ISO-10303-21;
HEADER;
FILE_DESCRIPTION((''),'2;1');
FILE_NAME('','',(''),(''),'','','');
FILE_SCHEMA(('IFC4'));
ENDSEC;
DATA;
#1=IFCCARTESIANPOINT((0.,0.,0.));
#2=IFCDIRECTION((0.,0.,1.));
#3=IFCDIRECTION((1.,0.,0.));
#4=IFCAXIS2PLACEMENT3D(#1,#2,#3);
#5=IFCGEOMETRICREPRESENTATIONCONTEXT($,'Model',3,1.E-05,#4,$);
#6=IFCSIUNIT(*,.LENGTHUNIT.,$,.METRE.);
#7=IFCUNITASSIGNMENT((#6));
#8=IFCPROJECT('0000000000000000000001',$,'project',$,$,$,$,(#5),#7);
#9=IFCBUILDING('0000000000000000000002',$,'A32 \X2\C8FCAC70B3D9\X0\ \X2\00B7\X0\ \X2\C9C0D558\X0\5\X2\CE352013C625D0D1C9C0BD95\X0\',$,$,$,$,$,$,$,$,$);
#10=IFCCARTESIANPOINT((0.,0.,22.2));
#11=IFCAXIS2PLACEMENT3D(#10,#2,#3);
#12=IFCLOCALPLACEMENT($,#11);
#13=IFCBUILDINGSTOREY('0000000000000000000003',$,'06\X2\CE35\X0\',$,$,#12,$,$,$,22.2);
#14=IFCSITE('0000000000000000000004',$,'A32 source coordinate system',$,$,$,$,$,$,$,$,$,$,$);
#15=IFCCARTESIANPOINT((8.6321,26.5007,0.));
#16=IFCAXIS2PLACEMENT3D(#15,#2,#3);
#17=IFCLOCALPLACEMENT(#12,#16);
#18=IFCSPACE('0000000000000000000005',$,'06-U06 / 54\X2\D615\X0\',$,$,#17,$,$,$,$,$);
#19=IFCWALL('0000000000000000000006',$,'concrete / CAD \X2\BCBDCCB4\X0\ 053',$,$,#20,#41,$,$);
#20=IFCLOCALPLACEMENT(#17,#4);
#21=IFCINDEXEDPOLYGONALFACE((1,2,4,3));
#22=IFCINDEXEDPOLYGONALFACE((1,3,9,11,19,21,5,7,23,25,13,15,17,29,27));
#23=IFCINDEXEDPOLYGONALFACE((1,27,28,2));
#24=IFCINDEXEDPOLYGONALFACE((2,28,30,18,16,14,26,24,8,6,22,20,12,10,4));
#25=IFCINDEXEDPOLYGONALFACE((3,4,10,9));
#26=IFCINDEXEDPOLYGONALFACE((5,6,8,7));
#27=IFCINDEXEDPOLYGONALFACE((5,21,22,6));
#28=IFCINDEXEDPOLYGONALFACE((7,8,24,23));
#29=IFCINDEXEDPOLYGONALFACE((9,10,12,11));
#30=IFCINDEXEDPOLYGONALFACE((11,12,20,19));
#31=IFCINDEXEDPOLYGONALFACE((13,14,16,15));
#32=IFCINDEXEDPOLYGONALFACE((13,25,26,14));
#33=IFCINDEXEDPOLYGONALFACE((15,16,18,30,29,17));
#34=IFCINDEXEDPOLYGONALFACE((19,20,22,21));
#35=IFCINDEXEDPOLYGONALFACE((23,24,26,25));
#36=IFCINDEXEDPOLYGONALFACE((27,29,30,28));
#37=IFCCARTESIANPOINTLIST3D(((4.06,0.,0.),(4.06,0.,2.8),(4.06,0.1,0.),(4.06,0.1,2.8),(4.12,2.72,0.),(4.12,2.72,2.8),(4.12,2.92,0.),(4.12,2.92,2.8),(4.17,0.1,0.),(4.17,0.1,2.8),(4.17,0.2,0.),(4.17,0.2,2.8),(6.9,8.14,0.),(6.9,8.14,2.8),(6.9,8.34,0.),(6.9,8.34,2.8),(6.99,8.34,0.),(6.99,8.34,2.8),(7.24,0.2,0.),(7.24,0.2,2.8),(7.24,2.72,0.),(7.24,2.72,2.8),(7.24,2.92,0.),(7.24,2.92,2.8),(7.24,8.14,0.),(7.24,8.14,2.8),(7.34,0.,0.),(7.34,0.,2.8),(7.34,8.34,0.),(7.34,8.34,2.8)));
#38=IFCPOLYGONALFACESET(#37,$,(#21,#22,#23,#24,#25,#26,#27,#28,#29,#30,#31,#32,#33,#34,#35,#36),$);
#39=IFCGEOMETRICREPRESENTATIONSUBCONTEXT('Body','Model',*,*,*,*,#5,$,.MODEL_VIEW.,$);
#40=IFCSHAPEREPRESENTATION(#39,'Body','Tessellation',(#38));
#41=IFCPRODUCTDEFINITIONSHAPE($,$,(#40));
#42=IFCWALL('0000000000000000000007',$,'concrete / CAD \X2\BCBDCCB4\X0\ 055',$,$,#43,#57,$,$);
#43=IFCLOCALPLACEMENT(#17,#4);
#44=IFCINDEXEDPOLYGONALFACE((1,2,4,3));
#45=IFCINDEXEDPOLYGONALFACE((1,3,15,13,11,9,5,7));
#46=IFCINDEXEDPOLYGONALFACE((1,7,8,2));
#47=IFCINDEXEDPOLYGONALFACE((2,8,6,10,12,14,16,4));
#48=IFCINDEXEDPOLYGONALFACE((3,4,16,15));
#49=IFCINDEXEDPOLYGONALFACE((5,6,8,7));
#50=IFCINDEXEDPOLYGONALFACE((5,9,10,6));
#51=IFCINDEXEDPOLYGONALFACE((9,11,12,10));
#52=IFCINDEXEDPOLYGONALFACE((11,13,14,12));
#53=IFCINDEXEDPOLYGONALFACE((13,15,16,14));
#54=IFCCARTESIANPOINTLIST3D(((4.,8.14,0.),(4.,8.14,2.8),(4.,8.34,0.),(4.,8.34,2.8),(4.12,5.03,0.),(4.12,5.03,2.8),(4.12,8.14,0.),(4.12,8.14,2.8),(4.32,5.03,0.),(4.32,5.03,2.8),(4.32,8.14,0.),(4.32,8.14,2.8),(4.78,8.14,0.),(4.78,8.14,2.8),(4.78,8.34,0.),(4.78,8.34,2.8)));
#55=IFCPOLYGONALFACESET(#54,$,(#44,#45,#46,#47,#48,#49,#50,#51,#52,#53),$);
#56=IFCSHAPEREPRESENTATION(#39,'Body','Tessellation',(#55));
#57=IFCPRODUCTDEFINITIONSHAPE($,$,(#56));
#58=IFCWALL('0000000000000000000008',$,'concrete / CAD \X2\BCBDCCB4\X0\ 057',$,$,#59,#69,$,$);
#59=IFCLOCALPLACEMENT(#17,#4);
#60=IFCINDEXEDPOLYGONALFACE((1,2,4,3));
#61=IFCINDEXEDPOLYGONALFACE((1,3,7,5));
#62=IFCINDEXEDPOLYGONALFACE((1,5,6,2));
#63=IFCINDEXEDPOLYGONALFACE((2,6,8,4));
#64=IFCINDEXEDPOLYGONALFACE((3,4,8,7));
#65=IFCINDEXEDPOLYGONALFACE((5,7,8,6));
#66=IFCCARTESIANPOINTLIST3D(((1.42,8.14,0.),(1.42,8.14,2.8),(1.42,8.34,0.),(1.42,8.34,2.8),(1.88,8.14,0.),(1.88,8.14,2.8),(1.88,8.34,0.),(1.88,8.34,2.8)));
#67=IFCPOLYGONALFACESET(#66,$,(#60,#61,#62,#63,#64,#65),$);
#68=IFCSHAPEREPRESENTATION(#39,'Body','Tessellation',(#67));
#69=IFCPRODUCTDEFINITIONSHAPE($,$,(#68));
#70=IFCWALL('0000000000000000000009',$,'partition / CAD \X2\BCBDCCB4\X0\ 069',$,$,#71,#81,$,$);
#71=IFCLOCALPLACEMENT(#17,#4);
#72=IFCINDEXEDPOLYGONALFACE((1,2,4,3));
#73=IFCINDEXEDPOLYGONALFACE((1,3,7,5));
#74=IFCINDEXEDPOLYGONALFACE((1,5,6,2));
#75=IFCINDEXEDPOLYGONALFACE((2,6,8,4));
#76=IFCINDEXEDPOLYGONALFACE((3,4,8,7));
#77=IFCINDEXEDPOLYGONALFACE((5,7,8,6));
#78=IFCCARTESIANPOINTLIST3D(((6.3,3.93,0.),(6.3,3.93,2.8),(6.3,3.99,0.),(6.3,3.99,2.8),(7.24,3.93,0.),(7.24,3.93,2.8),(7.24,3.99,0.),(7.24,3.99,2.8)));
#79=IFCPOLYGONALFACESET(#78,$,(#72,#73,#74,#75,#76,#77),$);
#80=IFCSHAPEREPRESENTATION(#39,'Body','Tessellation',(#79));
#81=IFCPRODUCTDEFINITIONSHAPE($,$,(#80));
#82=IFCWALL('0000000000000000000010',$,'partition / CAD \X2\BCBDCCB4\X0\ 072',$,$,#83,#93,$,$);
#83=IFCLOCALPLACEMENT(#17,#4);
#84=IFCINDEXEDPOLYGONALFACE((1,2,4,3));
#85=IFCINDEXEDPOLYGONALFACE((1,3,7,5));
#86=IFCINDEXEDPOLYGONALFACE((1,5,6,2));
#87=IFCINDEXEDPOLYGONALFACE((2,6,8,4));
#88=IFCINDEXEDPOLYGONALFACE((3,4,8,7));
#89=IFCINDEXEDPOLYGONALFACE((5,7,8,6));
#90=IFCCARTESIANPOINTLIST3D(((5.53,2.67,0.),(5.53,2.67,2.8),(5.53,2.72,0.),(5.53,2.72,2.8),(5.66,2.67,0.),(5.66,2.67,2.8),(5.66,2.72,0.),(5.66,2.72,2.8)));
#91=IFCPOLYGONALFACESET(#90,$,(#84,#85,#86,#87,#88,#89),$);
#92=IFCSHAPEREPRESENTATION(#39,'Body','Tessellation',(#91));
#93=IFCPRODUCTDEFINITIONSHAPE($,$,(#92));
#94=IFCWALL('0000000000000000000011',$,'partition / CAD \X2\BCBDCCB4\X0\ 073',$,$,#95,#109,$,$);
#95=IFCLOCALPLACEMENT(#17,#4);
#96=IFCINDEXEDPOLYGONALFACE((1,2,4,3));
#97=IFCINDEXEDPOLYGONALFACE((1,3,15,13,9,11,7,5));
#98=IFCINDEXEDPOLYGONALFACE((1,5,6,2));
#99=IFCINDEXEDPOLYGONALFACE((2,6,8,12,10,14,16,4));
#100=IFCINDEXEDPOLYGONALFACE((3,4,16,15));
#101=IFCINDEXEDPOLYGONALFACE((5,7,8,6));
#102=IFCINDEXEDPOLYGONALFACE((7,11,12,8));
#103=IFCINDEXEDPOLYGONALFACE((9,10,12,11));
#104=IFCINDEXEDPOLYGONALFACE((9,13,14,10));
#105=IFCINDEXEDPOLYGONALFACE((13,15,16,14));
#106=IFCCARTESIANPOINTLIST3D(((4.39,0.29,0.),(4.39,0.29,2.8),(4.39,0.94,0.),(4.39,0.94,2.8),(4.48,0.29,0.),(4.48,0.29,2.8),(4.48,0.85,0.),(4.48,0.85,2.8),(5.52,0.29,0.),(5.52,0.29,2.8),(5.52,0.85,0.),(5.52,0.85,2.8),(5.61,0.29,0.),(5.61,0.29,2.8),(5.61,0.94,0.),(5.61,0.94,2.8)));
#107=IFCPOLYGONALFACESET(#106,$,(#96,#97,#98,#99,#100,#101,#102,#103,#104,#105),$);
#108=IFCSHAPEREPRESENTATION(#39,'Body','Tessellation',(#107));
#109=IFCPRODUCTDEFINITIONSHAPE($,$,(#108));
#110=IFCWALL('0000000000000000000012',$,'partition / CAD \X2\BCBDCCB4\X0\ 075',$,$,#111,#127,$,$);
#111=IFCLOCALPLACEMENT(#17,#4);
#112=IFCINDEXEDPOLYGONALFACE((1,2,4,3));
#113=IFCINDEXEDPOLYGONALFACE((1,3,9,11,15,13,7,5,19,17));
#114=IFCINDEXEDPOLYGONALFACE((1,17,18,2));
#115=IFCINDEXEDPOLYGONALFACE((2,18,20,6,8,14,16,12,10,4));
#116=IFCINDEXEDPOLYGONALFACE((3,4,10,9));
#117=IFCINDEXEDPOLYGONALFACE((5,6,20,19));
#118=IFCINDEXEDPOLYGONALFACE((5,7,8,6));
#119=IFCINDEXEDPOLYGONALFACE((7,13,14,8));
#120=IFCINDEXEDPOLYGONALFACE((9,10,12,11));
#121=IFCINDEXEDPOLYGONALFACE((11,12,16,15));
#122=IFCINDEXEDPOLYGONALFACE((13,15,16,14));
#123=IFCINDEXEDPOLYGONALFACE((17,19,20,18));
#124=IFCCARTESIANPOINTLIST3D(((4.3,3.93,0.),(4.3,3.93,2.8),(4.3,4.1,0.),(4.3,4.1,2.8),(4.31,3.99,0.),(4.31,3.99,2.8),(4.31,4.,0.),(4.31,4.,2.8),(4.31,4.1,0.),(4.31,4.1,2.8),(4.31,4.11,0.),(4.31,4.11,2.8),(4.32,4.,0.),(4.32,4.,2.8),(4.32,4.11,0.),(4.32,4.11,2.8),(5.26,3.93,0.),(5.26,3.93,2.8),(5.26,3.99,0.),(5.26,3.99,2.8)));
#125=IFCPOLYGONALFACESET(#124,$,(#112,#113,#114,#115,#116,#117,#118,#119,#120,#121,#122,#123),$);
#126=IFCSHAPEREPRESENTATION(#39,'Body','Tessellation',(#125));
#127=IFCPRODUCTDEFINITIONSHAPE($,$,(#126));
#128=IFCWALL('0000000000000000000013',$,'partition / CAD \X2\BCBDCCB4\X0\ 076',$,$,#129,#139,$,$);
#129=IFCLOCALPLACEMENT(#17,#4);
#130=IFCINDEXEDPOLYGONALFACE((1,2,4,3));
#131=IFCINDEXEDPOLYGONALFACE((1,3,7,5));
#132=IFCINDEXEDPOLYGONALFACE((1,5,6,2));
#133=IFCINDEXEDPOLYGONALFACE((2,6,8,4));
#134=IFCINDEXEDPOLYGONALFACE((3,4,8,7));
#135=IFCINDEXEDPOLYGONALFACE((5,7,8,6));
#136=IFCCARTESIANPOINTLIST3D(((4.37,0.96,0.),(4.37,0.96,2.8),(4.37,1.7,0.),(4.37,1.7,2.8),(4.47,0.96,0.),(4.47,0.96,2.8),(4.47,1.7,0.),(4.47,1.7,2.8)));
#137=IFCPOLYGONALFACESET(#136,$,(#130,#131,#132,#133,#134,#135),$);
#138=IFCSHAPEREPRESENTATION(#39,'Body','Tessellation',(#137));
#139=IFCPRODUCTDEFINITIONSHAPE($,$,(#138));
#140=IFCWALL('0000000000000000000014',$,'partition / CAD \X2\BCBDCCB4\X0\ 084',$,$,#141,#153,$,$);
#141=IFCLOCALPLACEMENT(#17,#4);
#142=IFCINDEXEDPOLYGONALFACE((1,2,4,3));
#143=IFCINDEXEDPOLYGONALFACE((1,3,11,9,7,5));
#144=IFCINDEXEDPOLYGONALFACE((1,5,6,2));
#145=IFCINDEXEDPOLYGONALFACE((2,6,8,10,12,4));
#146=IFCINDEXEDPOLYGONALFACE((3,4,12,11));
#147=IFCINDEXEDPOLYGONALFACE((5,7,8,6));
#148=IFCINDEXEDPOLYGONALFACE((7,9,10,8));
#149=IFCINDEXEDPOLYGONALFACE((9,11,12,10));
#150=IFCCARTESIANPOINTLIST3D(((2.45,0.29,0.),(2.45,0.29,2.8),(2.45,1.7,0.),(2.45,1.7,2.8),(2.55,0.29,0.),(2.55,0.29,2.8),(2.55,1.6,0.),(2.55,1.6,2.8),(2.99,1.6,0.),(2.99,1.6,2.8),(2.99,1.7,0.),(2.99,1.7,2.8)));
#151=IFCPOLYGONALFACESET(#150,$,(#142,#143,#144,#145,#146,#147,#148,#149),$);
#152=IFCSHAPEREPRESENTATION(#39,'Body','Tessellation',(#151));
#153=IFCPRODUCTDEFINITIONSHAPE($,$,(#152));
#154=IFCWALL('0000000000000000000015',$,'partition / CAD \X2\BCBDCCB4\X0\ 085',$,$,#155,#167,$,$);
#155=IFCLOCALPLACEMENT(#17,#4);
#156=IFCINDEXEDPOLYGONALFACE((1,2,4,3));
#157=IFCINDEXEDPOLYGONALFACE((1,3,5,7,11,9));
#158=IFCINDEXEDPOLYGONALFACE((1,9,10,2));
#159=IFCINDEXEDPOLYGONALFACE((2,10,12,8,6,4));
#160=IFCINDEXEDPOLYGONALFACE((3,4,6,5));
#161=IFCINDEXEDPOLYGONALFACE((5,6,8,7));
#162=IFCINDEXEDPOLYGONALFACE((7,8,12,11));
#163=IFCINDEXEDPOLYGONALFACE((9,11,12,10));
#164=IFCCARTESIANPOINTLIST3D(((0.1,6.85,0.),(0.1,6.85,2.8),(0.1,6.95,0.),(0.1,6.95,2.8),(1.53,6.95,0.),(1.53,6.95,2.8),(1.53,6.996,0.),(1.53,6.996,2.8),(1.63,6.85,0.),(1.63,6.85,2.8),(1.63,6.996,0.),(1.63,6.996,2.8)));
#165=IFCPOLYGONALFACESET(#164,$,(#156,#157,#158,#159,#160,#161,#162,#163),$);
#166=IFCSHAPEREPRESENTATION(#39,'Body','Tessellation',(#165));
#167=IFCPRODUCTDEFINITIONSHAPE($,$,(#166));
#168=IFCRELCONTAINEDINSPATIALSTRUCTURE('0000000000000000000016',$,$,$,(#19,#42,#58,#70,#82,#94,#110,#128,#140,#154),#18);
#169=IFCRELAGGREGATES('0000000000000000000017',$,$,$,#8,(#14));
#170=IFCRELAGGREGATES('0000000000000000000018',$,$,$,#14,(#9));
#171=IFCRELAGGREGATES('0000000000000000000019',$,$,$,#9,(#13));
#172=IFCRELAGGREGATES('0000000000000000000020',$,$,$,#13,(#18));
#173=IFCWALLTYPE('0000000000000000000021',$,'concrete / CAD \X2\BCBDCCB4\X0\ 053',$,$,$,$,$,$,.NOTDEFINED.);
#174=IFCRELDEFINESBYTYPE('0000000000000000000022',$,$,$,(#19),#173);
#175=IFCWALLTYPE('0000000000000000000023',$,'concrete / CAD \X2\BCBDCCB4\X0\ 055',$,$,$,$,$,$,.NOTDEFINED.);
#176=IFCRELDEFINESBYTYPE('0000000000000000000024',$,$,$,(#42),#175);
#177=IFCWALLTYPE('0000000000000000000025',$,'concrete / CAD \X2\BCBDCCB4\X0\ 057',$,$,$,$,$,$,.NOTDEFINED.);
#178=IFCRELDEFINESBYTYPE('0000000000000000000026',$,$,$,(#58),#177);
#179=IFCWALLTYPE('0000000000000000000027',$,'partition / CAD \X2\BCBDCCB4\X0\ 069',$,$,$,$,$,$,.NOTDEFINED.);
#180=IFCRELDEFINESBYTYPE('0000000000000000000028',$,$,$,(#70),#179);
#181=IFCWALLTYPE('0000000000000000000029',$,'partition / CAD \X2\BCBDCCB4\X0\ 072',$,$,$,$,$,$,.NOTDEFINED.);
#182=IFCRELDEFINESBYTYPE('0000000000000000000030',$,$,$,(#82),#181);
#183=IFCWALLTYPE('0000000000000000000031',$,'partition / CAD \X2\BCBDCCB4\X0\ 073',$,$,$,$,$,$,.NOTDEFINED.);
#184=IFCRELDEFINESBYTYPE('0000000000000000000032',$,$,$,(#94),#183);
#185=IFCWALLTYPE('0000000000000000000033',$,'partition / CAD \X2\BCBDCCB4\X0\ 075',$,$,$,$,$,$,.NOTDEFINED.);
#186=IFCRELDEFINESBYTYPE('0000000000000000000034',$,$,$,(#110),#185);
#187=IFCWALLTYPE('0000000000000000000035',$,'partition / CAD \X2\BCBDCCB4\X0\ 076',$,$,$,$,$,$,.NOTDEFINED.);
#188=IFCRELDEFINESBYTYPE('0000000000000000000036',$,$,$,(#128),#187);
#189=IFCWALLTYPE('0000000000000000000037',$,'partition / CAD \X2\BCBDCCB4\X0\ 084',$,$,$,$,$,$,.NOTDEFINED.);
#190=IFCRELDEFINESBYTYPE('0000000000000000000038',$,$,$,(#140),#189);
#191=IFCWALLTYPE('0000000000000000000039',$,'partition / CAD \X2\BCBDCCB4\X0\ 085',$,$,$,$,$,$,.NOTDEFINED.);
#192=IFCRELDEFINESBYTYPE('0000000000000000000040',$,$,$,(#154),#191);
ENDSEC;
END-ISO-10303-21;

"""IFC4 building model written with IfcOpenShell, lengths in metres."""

from ifc_helpers import new_model, si_unit, frame, origin, origin_with_axes, place, context, subcontext, project, spatial, polyline, outline, extrude, source, transform, mapped, type_object, type_shapes, element, save


model = new_model("IFC4")

# Units and contexts
model_context = context("Model", 3, precision=1e-05, world=origin_with_axes())
body_context = subcontext(model_context, "Body", "Model", "MODEL_VIEW")
ifc_project = project(units=[si_unit("LENGTHUNIT", "METRE")], contexts=[model_context])

# Site, building, storey, space
site = spatial("IfcSite", under=ifc_project, Name="A32 source coordinate system")
building = spatial("IfcBuilding", under=site, Name="A32 주거동 · 지하5층–옥탑지붕")
storey_placement = place(None, frame((0.0, 0.0, 22.2), z_axis=(0.0, 0.0, 1.0), x_axis=(1.0, 0.0, 0.0)))
storey = spatial("IfcBuildingStorey", under=building, at=storey_placement, Name="06층", Elevation=22.2)
space_placement = place(storey_placement, frame((8.6321, 26.5007, 0.0), z_axis=(0.0, 0.0, 1.0), x_axis=(1.0, 0.0, 0.0)))
space = spatial("IfcSpace", under=storey, at=space_placement, Name="06-U06 / 54형")

# Walls
wall_type_1 = type_object("IfcWallType", Name="concrete / CAD 벽체 053", PredefinedType="NOTDEFINED")
shared_shape_1 = source(origin(), body_context, "Body", "SweptSolid", [
    extrude(outline(polyline([(7.24, 8.14), (6.9, 8.14), (6.9, 8.34), (6.99, 8.34), (6.99, 8.34), (7.34, 8.34), (7.34, 8.34), (7.34, 0.0), (4.06, 0.0), (4.06, 0.1), (4.17, 0.1), (4.17, 0.2), (7.24, 0.2), (7.24, 2.72), (4.12, 2.72), (4.12, 2.92), (7.24, 2.92), (7.24, 8.14)])), origin(), (0.0, 0.0, 1.0), 2.8),
])
type_shapes(wall_type_1, [shared_shape_1])
wall_1_placement = place(space_placement, origin_with_axes())
element("IfcWall", 1, at=wall_1_placement, inside=space, type_object=wall_type_1, Name="concrete / CAD 벽체 053", context=body_context, shape_type="MappedRepresentation", body=[
    mapped(shared_shape_1, transform((0.0, 0.0, 0.0), scale=1.0)),
])
wall_type_2 = type_object("IfcWallType", Name="concrete / CAD 벽체 055", PredefinedType="NOTDEFINED")
shared_shape_2 = source(origin(), body_context, "Body", "SweptSolid", [
    extrude(outline(polyline([(4.32, 5.03), (4.12, 5.03), (4.12, 8.14), (4.0, 8.14), (4.0, 8.34), (4.78, 8.34), (4.78, 8.14), (4.32, 8.14), (4.32, 5.03)])), origin(), (0.0, 0.0, 1.0), 2.8),
])
type_shapes(wall_type_2, [shared_shape_2])
wall_2_placement = place(space_placement, origin_with_axes())
element("IfcWall", 2, at=wall_2_placement, inside=space, type_object=wall_type_2, Name="concrete / CAD 벽체 055", context=body_context, shape_type="MappedRepresentation", body=[
    mapped(shared_shape_2, transform((0.0, 0.0, 0.0), scale=1.0)),
])
wall_type_3 = type_object("IfcWallType", Name="concrete / CAD 벽체 057", PredefinedType="NOTDEFINED")
shared_shape_3 = source(origin(), body_context, "Body", "SweptSolid", [
    extrude(outline(polyline([(1.42, 8.14), (1.42, 8.34), (1.88, 8.34), (1.88, 8.14), (1.42, 8.14)])), origin(), (0.0, 0.0, 1.0), 2.8),
])
type_shapes(wall_type_3, [shared_shape_3])
wall_3_placement = place(space_placement, origin_with_axes())
element("IfcWall", 3, at=wall_3_placement, inside=space, type_object=wall_type_3, Name="concrete / CAD 벽체 057", context=body_context, shape_type="MappedRepresentation", body=[
    mapped(shared_shape_3, transform((0.0, 0.0, 0.0), scale=1.0)),
])
wall_type_4 = type_object("IfcWallType", Name="partition / CAD 벽체 069", PredefinedType="NOTDEFINED")
shared_shape_4 = source(origin(), body_context, "Body", "SweptSolid", [
    extrude(outline(polyline([(7.24, 3.93), (6.3, 3.93), (6.3, 3.99), (7.24, 3.99), (7.24, 3.93)])), origin(), (0.0, 0.0, 1.0), 2.8),
])
type_shapes(wall_type_4, [shared_shape_4])
wall_4_placement = place(space_placement, origin_with_axes())
element("IfcWall", 4, at=wall_4_placement, inside=space, type_object=wall_type_4, Name="partition / CAD 벽체 069", context=body_context, shape_type="MappedRepresentation", body=[
    mapped(shared_shape_4, transform((0.0, 0.0, 0.0), scale=1.0)),
])
wall_type_5 = type_object("IfcWallType", Name="partition / CAD 벽체 072", PredefinedType="NOTDEFINED")
shared_shape_5 = source(origin(), body_context, "Body", "SweptSolid", [
    extrude(outline(polyline([(5.66, 2.67), (5.53, 2.67), (5.53, 2.72), (5.66, 2.72), (5.66, 2.67)])), origin(), (0.0, 0.0, 1.0), 2.8),
])
type_shapes(wall_type_5, [shared_shape_5])
wall_5_placement = place(space_placement, origin_with_axes())
element("IfcWall", 5, at=wall_5_placement, inside=space, type_object=wall_type_5, Name="partition / CAD 벽체 072", context=body_context, shape_type="MappedRepresentation", body=[
    mapped(shared_shape_5, transform((0.0, 0.0, 0.0), scale=1.0)),
])
wall_type_6 = type_object("IfcWallType", Name="partition / CAD 벽체 073", PredefinedType="NOTDEFINED")
shared_shape_6 = source(origin(), body_context, "Body", "SweptSolid", [
    extrude(outline(polyline([(4.48, 0.29), (4.39, 0.29), (4.39, 0.94), (5.61, 0.94), (5.61, 0.29), (5.52, 0.29), (5.52, 0.85), (4.48, 0.85), (4.48, 0.29)])), origin(), (0.0, 0.0, 1.0), 2.8),
])
type_shapes(wall_type_6, [shared_shape_6])
wall_6_placement = place(space_placement, origin_with_axes())
element("IfcWall", 6, at=wall_6_placement, inside=space, type_object=wall_type_6, Name="partition / CAD 벽체 073", context=body_context, shape_type="MappedRepresentation", body=[
    mapped(shared_shape_6, transform((0.0, 0.0, 0.0), scale=1.0)),
])
wall_type_7 = type_object("IfcWallType", Name="partition / CAD 벽체 075", PredefinedType="NOTDEFINED")
shared_shape_7 = source(origin(), body_context, "Body", "SweptSolid", [
    extrude(outline(polyline([(4.32, 4.0), (4.31, 4.0), (4.31, 3.99), (5.26, 3.99), (5.26, 3.93), (4.3, 3.93), (4.3, 4.1), (4.31, 4.1), (4.31, 4.11), (4.32, 4.11), (4.32, 4.0)])), origin(), (0.0, 0.0, 1.0), 2.8),
])
type_shapes(wall_type_7, [shared_shape_7])
wall_7_placement = place(space_placement, origin_with_axes())
element("IfcWall", 7, at=wall_7_placement, inside=space, type_object=wall_type_7, Name="partition / CAD 벽체 075", context=body_context, shape_type="MappedRepresentation", body=[
    mapped(shared_shape_7, transform((0.0, 0.0, 0.0), scale=1.0)),
])
wall_type_8 = type_object("IfcWallType", Name="partition / CAD 벽체 076", PredefinedType="NOTDEFINED")
shared_shape_8 = source(origin(), body_context, "Body", "SweptSolid", [
    extrude(outline(polyline([(4.37, 1.7), (4.47, 1.7), (4.47, 0.96), (4.37, 0.96), (4.37, 1.7)])), origin(), (0.0, 0.0, 1.0), 2.8),
])
type_shapes(wall_type_8, [shared_shape_8])
wall_8_placement = place(space_placement, origin_with_axes())
element("IfcWall", 8, at=wall_8_placement, inside=space, type_object=wall_type_8, Name="partition / CAD 벽체 076", context=body_context, shape_type="MappedRepresentation", body=[
    mapped(shared_shape_8, transform((0.0, 0.0, 0.0), scale=1.0)),
])
wall_type_9 = type_object("IfcWallType", Name="partition / CAD 벽체 084", PredefinedType="NOTDEFINED")
shared_shape_9 = source(origin(), body_context, "Body", "SweptSolid", [
    extrude(outline(polyline([(2.99, 1.6), (2.55, 1.6), (2.55, 0.29), (2.45, 0.29), (2.45, 1.7), (2.99, 1.7), (2.99, 1.6)])), origin(), (0.0, 0.0, 1.0), 2.8),
])
type_shapes(wall_type_9, [shared_shape_9])
wall_9_placement = place(space_placement, origin_with_axes())
element("IfcWall", 9, at=wall_9_placement, inside=space, type_object=wall_type_9, Name="partition / CAD 벽체 084", context=body_context, shape_type="MappedRepresentation", body=[
    mapped(shared_shape_9, transform((0.0, 0.0, 0.0), scale=1.0)),
])
wall_type_10 = type_object("IfcWallType", Name="partition / CAD 벽체 085", PredefinedType="NOTDEFINED")
shared_shape_10 = source(origin(), body_context, "Body", "SweptSolid", [
    extrude(outline(polyline([(1.63, 6.85), (0.1, 6.85), (0.1, 6.95), (1.53, 6.95), (1.53, 6.996), (1.63, 6.996), (1.63, 6.85)])), origin(), (0.0, 0.0, 1.0), 2.8),
])
type_shapes(wall_type_10, [shared_shape_10])
wall_10_placement = place(space_placement, origin_with_axes())
element("IfcWall", 10, at=wall_10_placement, inside=space, type_object=wall_type_10, Name="partition / CAD 벽체 085", context=body_context, shape_type="MappedRepresentation", body=[
    mapped(shared_shape_10, transform((0.0, 0.0, 0.0), scale=1.0)),
])

save(model, "model.ifc")
